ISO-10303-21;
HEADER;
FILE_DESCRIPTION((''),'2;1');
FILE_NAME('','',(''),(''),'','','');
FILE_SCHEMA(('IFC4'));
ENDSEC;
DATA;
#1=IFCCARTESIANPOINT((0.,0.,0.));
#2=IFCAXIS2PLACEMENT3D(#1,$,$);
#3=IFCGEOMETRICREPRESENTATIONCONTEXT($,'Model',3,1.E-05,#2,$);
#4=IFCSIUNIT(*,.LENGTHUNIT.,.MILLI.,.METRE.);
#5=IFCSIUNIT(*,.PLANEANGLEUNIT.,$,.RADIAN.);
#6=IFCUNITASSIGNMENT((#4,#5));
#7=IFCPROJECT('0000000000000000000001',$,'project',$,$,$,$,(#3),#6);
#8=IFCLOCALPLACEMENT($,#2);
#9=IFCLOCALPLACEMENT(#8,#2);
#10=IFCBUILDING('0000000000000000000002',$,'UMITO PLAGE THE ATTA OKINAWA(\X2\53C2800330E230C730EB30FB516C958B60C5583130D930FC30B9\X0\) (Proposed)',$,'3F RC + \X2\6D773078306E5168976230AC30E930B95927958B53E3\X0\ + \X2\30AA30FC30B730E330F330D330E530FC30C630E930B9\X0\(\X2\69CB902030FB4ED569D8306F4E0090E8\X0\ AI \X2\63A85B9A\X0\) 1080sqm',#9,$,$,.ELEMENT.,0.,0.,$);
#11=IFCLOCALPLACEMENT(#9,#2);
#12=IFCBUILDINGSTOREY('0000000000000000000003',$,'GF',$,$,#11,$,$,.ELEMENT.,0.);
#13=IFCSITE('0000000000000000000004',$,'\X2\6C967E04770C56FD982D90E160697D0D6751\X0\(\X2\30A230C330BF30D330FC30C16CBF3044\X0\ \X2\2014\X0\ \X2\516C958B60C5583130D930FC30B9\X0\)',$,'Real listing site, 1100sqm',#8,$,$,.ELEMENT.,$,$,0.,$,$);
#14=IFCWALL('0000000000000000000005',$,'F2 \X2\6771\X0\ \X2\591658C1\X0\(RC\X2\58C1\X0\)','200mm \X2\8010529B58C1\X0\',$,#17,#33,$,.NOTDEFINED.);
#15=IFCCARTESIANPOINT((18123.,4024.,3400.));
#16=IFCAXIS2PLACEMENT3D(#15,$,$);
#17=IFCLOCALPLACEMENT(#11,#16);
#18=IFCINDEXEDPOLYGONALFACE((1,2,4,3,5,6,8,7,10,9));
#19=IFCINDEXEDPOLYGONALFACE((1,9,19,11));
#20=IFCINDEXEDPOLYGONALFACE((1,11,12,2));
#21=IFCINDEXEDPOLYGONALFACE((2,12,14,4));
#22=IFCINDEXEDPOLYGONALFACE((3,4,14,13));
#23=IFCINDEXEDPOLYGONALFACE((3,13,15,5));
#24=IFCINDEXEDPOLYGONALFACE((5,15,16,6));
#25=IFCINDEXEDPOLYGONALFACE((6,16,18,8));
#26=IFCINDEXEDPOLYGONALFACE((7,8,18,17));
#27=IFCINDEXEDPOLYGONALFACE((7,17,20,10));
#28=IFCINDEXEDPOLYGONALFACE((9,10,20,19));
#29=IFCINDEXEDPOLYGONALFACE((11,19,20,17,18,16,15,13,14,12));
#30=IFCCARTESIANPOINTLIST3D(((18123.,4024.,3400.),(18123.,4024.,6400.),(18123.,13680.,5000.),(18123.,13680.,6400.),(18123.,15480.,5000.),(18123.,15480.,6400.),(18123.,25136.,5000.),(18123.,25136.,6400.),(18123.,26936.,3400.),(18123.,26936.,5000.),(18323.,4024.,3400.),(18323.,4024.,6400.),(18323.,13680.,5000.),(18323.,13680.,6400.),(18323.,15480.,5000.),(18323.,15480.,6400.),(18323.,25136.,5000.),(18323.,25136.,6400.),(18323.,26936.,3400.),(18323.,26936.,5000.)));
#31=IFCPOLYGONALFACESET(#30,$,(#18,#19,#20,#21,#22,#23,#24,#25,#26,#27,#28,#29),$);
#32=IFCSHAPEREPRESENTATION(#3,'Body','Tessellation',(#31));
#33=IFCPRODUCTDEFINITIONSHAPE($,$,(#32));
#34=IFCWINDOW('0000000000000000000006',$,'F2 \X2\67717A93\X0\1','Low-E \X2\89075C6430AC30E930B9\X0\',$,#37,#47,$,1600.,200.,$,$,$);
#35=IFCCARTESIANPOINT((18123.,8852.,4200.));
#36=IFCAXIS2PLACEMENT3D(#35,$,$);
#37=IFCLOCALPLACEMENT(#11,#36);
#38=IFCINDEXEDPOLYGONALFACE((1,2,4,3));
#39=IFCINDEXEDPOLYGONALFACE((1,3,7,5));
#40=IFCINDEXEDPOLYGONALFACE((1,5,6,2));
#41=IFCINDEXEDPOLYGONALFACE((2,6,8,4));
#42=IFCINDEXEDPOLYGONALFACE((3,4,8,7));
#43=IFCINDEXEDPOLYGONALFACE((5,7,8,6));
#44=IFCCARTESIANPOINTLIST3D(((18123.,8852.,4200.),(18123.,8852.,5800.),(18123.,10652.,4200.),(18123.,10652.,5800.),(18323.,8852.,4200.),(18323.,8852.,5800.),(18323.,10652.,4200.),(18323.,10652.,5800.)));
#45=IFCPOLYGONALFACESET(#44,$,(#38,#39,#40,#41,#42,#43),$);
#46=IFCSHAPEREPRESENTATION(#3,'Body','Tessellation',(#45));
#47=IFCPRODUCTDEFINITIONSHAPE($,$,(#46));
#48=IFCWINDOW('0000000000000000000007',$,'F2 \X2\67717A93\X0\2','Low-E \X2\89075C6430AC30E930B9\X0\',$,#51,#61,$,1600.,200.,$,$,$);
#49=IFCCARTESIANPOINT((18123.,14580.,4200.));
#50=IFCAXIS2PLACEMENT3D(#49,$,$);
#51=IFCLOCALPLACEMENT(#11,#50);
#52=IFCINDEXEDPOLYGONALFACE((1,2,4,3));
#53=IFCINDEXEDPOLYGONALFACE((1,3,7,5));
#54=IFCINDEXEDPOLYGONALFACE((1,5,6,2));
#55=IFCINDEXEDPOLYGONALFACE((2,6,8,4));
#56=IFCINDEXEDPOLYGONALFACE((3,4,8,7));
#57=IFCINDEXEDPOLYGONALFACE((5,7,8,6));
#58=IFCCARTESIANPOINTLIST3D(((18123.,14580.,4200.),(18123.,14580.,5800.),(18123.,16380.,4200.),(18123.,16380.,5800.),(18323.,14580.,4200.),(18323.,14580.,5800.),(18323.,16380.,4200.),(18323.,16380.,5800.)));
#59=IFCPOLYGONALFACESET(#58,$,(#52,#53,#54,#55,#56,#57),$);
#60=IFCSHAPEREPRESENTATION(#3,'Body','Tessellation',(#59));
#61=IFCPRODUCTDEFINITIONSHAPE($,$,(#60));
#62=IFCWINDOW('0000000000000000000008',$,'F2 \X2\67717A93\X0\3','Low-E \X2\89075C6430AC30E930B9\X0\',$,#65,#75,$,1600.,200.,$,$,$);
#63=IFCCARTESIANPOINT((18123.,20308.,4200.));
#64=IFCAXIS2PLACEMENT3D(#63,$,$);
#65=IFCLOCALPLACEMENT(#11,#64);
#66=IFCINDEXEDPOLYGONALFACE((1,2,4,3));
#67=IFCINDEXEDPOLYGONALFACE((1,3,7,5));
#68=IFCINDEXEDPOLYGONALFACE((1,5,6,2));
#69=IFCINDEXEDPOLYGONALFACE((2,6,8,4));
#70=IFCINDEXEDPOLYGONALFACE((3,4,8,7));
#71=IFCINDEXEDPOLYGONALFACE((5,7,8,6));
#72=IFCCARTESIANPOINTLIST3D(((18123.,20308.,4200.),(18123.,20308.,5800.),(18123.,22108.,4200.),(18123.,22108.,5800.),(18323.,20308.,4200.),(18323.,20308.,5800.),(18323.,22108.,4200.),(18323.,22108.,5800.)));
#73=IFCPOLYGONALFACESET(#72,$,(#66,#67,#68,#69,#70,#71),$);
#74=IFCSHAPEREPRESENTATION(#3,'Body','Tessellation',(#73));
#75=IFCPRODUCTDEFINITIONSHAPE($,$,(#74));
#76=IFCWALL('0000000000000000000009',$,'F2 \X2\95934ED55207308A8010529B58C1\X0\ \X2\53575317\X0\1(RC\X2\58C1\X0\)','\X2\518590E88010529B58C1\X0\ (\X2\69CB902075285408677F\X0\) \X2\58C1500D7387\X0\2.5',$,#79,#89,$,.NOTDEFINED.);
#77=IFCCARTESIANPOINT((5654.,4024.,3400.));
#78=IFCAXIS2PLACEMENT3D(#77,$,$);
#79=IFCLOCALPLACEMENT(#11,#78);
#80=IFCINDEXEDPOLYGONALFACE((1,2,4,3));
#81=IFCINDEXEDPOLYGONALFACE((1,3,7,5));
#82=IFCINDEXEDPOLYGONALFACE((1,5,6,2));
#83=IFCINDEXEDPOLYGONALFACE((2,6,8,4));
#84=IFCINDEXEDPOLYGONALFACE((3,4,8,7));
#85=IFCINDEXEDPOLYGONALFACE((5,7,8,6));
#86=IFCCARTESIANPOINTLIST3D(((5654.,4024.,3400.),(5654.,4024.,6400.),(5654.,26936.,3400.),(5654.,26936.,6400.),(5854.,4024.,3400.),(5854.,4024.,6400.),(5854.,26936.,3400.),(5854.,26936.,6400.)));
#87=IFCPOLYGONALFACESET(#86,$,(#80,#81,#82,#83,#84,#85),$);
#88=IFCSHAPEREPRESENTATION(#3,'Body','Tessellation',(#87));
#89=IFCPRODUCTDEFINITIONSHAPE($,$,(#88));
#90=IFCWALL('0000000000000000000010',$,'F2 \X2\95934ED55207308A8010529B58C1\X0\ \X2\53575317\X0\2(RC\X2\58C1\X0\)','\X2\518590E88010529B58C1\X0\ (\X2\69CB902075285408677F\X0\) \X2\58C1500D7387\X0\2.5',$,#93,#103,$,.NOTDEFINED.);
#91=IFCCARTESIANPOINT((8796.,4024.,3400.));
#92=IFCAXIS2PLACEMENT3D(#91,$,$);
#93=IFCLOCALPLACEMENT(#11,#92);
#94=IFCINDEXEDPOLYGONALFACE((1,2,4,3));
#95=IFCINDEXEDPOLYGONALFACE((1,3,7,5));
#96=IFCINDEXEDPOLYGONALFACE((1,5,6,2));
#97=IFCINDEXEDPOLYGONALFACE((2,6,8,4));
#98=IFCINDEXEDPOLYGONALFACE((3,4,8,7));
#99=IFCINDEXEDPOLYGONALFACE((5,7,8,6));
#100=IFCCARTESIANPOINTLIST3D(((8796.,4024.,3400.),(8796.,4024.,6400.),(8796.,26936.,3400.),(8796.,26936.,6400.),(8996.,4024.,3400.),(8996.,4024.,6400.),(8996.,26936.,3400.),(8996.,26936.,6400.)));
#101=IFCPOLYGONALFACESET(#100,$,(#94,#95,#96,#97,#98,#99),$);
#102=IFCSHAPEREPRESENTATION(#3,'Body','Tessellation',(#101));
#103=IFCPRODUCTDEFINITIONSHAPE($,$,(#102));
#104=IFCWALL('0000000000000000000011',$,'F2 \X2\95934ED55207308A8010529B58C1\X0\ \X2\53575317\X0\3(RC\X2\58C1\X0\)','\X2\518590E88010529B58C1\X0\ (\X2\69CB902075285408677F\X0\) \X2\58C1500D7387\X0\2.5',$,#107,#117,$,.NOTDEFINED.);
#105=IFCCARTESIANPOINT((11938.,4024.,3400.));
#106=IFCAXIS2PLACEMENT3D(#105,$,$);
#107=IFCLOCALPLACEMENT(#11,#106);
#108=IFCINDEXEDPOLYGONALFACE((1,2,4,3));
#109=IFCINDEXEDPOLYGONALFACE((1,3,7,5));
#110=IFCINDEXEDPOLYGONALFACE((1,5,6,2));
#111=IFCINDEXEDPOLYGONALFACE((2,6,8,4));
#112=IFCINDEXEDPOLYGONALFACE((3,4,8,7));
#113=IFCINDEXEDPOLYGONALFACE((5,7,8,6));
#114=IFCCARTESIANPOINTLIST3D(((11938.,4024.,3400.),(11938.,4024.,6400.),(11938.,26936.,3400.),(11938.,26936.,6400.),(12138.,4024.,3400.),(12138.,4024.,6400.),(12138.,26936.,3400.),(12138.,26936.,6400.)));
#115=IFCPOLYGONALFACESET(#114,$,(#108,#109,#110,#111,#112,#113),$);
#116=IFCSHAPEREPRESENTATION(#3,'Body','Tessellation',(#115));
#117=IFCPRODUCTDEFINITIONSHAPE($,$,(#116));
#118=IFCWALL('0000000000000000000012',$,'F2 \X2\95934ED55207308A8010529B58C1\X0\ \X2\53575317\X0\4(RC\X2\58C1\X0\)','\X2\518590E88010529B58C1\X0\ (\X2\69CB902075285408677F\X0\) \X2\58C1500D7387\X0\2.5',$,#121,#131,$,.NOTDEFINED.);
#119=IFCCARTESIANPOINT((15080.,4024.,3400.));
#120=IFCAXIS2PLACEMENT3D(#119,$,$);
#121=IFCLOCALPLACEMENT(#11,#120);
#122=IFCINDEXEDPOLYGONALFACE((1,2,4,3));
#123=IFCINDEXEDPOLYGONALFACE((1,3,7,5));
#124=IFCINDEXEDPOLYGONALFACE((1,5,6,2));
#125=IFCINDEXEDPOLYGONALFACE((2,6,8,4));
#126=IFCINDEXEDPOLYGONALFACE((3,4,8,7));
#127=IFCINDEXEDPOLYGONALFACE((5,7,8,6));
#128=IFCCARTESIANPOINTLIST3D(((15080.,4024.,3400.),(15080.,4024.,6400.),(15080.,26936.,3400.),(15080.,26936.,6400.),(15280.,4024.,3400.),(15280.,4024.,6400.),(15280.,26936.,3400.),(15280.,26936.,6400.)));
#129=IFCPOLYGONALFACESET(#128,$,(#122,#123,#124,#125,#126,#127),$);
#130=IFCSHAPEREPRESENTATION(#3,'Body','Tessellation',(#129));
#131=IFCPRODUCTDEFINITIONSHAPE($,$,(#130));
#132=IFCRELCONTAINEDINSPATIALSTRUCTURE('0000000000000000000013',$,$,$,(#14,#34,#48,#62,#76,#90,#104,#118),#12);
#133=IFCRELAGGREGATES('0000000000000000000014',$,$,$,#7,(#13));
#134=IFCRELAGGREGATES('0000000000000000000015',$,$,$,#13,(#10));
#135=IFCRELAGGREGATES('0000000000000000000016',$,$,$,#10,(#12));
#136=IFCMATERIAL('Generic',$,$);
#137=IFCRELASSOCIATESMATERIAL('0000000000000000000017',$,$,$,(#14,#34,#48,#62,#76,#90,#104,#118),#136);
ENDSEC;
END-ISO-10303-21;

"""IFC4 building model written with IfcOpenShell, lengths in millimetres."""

from ifc_helpers import new_model, si_unit, frame, frame_2d, origin, place, context, project, spatial, rectangle, extrude, material, element, fill, save


model = new_model("IFC4")

# Units and contexts
model_context = context("Model", 3, precision=1e-05, world=origin())
ifc_project = project(units=[si_unit("LENGTHUNIT", "METRE", prefix="MILLI"), si_unit("PLANEANGLEUNIT", "RADIAN")], contexts=[model_context])

# Site, building, storey
site_placement = place(None, origin())
site = spatial("IfcSite", under=ifc_project, at=site_placement, Name="沖縄県国頭郡恩納村(アッタビーチ沿い — 公開情報ベース)", ObjectType="Real listing site, 1100sqm", CompositionType="ELEMENT", RefElevation=0.0)
building_placement = place(site_placement, origin())
building = spatial("IfcBuilding", under=site, at=building_placement, Name="UMITO PLAGE THE ATTA OKINAWA(参考モデル・公開情報ベース) (Proposed)", ObjectType="3F RC + 海への全面ガラス大開口 + オーシャンビューテラス(構造・仕様は一部 AI 推定) 1080sqm", CompositionType="ELEMENT", ElevationOfRefHeight=0.0, ElevationOfTerrain=0.0)
storey_placement = place(building_placement, origin())
storey = spatial("IfcBuildingStorey", under=building, at=storey_placement, Name="GF", CompositionType="ELEMENT", Elevation=0.0)

# Shared definitions
ifc_material = material(Name="Generic")

# Wall, openings, windows
wall_1_placement = place(storey_placement, frame((18123.0, 4024.0, 3400.0)))
wall_1 = element("IfcWall", 1, at=wall_1_placement, inside=storey, material=ifc_material, Name="F2 東 外壁(RC壁)", Description="200mm 耐力壁", PredefinedType="NOTDEFINED", context=model_context, shape_type="SweptSolid", body=[
    extrude(rectangle(XDim=200.0, YDim=22912.0, at=frame_2d((100.0, 11456.0))), frame((18123.0, 4024.0, 3400.0)), (0.0, 0.0, 1.0), 3000.0),
])
opening_1_placement = place(storey_placement, frame((18123.0, 8852.0, 4200.0)))
opening_1 = element("IfcOpeningElement", 2, at=opening_1_placement, cuts=wall_1, PredefinedType="NOTDEFINED", context=model_context, shape_type="SweptSolid", body=[
    extrude(rectangle(XDim=200.0, YDim=1800.0, at=frame_2d((100.0, 900.0))), frame((18123.0, 8852.0, 4200.0)), (0.0, 0.0, 1.0), 1600.0),
])
opening_2_placement = place(storey_placement, frame((18123.0, 14580.0, 4200.0)))
opening_2 = element("IfcOpeningElement", 3, at=opening_2_placement, cuts=wall_1, PredefinedType="NOTDEFINED", context=model_context, shape_type="SweptSolid", body=[
    extrude(rectangle(XDim=200.0, YDim=1800.0, at=frame_2d((100.0, 900.0))), frame((18123.0, 14580.0, 4200.0)), (0.0, 0.0, 1.0), 1600.0),
])
opening_3_placement = place(storey_placement, frame((18123.0, 20308.0, 4200.0)))
opening_3 = element("IfcOpeningElement", 4, at=opening_3_placement, cuts=wall_1, PredefinedType="NOTDEFINED", context=model_context, shape_type="SweptSolid", body=[
    extrude(rectangle(XDim=200.0, YDim=1800.0, at=frame_2d((100.0, 900.0))), frame((18123.0, 20308.0, 4200.0)), (0.0, 0.0, 1.0), 1600.0),
])
window_1_placement = place(storey_placement, frame((18123.0, 8852.0, 4200.0)))
window_1 = element("IfcWindow", 5, at=window_1_placement, inside=storey, material=ifc_material, Name="F2 東窓1", Description="Low-E 複層ガラス", OverallHeight=1600.0, OverallWidth=200.0, context=model_context, shape_type="SweptSolid", body=[
    extrude(rectangle(XDim=200.0, YDim=1800.0, at=frame_2d((100.0, 900.0))), frame((18123.0, 8852.0, 4200.0)), (0.0, 0.0, 1.0), 1600.0),
])
fill(opening_1, window_1)
window_2_placement = place(storey_placement, frame((18123.0, 14580.0, 4200.0)))
window_2 = element("IfcWindow", 6, at=window_2_placement, inside=storey, material=ifc_material, Name="F2 東窓2", Description="Low-E 複層ガラス", OverallHeight=1600.0, OverallWidth=200.0, context=model_context, shape_type="SweptSolid", body=[
    extrude(rectangle(XDim=200.0, YDim=1800.0, at=frame_2d((100.0, 900.0))), frame((18123.0, 14580.0, 4200.0)), (0.0, 0.0, 1.0), 1600.0),
])
fill(opening_2, window_2)
window_3_placement = place(storey_placement, frame((18123.0, 20308.0, 4200.0)))
window_3 = element("IfcWindow", 7, at=window_3_placement, inside=storey, material=ifc_material, Name="F2 東窓3", Description="Low-E 複層ガラス", OverallHeight=1600.0, OverallWidth=200.0, context=model_context, shape_type="SweptSolid", body=[
    extrude(rectangle(XDim=200.0, YDim=1800.0, at=frame_2d((100.0, 900.0))), frame((18123.0, 20308.0, 4200.0)), (0.0, 0.0, 1.0), 1600.0),
])
fill(opening_3, window_3)

# Walls
wall_2_placement = place(storey_placement, frame((5654.0, 4024.0, 3400.0)))
element("IfcWall", 8, at=wall_2_placement, inside=storey, material=ifc_material, Name="F2 間仕切り耐力壁 南北1(RC壁)", Description="内部耐力壁 (構造用合板) 壁倍率2.5", PredefinedType="NOTDEFINED", context=model_context, shape_type="SweptSolid", body=[
    extrude(rectangle(XDim=200.0, YDim=22912.0, at=frame_2d((100.0, 11456.0))), frame((5654.0, 4024.0, 3400.0)), (0.0, 0.0, 1.0), 3000.0),
])
wall_3_placement = place(storey_placement, frame((8796.0, 4024.0, 3400.0)))
element("IfcWall", 9, at=wall_3_placement, inside=storey, material=ifc_material, Name="F2 間仕切り耐力壁 南北2(RC壁)", Description="内部耐力壁 (構造用合板) 壁倍率2.5", PredefinedType="NOTDEFINED", context=model_context, shape_type="SweptSolid", body=[
    extrude(rectangle(XDim=200.0, YDim=22912.0, at=frame_2d((100.0, 11456.0))), frame((8796.0, 4024.0, 3400.0)), (0.0, 0.0, 1.0), 3000.0),
])
wall_4_placement = place(storey_placement, frame((11938.0, 4024.0, 3400.0)))
element("IfcWall", 10, at=wall_4_placement, inside=storey, material=ifc_material, Name="F2 間仕切り耐力壁 南北3(RC壁)", Description="内部耐力壁 (構造用合板) 壁倍率2.5", PredefinedType="NOTDEFINED", context=model_context, shape_type="SweptSolid", body=[
    extrude(rectangle(XDim=200.0, YDim=22912.0, at=frame_2d((100.0, 11456.0))), frame((11938.0, 4024.0, 3400.0)), (0.0, 0.0, 1.0), 3000.0),
])
wall_5_placement = place(storey_placement, frame((15080.0, 4024.0, 3400.0)))
element("IfcWall", 11, at=wall_5_placement, inside=storey, material=ifc_material, Name="F2 間仕切り耐力壁 南北4(RC壁)", Description="内部耐力壁 (構造用合板) 壁倍率2.5", PredefinedType="NOTDEFINED", context=model_context, shape_type="SweptSolid", body=[
    extrude(rectangle(XDim=200.0, YDim=22912.0, at=frame_2d((100.0, 11456.0))), frame((15080.0, 4024.0, 3400.0)), (0.0, 0.0, 1.0), 3000.0),
])

save(model, "model.ifc")
